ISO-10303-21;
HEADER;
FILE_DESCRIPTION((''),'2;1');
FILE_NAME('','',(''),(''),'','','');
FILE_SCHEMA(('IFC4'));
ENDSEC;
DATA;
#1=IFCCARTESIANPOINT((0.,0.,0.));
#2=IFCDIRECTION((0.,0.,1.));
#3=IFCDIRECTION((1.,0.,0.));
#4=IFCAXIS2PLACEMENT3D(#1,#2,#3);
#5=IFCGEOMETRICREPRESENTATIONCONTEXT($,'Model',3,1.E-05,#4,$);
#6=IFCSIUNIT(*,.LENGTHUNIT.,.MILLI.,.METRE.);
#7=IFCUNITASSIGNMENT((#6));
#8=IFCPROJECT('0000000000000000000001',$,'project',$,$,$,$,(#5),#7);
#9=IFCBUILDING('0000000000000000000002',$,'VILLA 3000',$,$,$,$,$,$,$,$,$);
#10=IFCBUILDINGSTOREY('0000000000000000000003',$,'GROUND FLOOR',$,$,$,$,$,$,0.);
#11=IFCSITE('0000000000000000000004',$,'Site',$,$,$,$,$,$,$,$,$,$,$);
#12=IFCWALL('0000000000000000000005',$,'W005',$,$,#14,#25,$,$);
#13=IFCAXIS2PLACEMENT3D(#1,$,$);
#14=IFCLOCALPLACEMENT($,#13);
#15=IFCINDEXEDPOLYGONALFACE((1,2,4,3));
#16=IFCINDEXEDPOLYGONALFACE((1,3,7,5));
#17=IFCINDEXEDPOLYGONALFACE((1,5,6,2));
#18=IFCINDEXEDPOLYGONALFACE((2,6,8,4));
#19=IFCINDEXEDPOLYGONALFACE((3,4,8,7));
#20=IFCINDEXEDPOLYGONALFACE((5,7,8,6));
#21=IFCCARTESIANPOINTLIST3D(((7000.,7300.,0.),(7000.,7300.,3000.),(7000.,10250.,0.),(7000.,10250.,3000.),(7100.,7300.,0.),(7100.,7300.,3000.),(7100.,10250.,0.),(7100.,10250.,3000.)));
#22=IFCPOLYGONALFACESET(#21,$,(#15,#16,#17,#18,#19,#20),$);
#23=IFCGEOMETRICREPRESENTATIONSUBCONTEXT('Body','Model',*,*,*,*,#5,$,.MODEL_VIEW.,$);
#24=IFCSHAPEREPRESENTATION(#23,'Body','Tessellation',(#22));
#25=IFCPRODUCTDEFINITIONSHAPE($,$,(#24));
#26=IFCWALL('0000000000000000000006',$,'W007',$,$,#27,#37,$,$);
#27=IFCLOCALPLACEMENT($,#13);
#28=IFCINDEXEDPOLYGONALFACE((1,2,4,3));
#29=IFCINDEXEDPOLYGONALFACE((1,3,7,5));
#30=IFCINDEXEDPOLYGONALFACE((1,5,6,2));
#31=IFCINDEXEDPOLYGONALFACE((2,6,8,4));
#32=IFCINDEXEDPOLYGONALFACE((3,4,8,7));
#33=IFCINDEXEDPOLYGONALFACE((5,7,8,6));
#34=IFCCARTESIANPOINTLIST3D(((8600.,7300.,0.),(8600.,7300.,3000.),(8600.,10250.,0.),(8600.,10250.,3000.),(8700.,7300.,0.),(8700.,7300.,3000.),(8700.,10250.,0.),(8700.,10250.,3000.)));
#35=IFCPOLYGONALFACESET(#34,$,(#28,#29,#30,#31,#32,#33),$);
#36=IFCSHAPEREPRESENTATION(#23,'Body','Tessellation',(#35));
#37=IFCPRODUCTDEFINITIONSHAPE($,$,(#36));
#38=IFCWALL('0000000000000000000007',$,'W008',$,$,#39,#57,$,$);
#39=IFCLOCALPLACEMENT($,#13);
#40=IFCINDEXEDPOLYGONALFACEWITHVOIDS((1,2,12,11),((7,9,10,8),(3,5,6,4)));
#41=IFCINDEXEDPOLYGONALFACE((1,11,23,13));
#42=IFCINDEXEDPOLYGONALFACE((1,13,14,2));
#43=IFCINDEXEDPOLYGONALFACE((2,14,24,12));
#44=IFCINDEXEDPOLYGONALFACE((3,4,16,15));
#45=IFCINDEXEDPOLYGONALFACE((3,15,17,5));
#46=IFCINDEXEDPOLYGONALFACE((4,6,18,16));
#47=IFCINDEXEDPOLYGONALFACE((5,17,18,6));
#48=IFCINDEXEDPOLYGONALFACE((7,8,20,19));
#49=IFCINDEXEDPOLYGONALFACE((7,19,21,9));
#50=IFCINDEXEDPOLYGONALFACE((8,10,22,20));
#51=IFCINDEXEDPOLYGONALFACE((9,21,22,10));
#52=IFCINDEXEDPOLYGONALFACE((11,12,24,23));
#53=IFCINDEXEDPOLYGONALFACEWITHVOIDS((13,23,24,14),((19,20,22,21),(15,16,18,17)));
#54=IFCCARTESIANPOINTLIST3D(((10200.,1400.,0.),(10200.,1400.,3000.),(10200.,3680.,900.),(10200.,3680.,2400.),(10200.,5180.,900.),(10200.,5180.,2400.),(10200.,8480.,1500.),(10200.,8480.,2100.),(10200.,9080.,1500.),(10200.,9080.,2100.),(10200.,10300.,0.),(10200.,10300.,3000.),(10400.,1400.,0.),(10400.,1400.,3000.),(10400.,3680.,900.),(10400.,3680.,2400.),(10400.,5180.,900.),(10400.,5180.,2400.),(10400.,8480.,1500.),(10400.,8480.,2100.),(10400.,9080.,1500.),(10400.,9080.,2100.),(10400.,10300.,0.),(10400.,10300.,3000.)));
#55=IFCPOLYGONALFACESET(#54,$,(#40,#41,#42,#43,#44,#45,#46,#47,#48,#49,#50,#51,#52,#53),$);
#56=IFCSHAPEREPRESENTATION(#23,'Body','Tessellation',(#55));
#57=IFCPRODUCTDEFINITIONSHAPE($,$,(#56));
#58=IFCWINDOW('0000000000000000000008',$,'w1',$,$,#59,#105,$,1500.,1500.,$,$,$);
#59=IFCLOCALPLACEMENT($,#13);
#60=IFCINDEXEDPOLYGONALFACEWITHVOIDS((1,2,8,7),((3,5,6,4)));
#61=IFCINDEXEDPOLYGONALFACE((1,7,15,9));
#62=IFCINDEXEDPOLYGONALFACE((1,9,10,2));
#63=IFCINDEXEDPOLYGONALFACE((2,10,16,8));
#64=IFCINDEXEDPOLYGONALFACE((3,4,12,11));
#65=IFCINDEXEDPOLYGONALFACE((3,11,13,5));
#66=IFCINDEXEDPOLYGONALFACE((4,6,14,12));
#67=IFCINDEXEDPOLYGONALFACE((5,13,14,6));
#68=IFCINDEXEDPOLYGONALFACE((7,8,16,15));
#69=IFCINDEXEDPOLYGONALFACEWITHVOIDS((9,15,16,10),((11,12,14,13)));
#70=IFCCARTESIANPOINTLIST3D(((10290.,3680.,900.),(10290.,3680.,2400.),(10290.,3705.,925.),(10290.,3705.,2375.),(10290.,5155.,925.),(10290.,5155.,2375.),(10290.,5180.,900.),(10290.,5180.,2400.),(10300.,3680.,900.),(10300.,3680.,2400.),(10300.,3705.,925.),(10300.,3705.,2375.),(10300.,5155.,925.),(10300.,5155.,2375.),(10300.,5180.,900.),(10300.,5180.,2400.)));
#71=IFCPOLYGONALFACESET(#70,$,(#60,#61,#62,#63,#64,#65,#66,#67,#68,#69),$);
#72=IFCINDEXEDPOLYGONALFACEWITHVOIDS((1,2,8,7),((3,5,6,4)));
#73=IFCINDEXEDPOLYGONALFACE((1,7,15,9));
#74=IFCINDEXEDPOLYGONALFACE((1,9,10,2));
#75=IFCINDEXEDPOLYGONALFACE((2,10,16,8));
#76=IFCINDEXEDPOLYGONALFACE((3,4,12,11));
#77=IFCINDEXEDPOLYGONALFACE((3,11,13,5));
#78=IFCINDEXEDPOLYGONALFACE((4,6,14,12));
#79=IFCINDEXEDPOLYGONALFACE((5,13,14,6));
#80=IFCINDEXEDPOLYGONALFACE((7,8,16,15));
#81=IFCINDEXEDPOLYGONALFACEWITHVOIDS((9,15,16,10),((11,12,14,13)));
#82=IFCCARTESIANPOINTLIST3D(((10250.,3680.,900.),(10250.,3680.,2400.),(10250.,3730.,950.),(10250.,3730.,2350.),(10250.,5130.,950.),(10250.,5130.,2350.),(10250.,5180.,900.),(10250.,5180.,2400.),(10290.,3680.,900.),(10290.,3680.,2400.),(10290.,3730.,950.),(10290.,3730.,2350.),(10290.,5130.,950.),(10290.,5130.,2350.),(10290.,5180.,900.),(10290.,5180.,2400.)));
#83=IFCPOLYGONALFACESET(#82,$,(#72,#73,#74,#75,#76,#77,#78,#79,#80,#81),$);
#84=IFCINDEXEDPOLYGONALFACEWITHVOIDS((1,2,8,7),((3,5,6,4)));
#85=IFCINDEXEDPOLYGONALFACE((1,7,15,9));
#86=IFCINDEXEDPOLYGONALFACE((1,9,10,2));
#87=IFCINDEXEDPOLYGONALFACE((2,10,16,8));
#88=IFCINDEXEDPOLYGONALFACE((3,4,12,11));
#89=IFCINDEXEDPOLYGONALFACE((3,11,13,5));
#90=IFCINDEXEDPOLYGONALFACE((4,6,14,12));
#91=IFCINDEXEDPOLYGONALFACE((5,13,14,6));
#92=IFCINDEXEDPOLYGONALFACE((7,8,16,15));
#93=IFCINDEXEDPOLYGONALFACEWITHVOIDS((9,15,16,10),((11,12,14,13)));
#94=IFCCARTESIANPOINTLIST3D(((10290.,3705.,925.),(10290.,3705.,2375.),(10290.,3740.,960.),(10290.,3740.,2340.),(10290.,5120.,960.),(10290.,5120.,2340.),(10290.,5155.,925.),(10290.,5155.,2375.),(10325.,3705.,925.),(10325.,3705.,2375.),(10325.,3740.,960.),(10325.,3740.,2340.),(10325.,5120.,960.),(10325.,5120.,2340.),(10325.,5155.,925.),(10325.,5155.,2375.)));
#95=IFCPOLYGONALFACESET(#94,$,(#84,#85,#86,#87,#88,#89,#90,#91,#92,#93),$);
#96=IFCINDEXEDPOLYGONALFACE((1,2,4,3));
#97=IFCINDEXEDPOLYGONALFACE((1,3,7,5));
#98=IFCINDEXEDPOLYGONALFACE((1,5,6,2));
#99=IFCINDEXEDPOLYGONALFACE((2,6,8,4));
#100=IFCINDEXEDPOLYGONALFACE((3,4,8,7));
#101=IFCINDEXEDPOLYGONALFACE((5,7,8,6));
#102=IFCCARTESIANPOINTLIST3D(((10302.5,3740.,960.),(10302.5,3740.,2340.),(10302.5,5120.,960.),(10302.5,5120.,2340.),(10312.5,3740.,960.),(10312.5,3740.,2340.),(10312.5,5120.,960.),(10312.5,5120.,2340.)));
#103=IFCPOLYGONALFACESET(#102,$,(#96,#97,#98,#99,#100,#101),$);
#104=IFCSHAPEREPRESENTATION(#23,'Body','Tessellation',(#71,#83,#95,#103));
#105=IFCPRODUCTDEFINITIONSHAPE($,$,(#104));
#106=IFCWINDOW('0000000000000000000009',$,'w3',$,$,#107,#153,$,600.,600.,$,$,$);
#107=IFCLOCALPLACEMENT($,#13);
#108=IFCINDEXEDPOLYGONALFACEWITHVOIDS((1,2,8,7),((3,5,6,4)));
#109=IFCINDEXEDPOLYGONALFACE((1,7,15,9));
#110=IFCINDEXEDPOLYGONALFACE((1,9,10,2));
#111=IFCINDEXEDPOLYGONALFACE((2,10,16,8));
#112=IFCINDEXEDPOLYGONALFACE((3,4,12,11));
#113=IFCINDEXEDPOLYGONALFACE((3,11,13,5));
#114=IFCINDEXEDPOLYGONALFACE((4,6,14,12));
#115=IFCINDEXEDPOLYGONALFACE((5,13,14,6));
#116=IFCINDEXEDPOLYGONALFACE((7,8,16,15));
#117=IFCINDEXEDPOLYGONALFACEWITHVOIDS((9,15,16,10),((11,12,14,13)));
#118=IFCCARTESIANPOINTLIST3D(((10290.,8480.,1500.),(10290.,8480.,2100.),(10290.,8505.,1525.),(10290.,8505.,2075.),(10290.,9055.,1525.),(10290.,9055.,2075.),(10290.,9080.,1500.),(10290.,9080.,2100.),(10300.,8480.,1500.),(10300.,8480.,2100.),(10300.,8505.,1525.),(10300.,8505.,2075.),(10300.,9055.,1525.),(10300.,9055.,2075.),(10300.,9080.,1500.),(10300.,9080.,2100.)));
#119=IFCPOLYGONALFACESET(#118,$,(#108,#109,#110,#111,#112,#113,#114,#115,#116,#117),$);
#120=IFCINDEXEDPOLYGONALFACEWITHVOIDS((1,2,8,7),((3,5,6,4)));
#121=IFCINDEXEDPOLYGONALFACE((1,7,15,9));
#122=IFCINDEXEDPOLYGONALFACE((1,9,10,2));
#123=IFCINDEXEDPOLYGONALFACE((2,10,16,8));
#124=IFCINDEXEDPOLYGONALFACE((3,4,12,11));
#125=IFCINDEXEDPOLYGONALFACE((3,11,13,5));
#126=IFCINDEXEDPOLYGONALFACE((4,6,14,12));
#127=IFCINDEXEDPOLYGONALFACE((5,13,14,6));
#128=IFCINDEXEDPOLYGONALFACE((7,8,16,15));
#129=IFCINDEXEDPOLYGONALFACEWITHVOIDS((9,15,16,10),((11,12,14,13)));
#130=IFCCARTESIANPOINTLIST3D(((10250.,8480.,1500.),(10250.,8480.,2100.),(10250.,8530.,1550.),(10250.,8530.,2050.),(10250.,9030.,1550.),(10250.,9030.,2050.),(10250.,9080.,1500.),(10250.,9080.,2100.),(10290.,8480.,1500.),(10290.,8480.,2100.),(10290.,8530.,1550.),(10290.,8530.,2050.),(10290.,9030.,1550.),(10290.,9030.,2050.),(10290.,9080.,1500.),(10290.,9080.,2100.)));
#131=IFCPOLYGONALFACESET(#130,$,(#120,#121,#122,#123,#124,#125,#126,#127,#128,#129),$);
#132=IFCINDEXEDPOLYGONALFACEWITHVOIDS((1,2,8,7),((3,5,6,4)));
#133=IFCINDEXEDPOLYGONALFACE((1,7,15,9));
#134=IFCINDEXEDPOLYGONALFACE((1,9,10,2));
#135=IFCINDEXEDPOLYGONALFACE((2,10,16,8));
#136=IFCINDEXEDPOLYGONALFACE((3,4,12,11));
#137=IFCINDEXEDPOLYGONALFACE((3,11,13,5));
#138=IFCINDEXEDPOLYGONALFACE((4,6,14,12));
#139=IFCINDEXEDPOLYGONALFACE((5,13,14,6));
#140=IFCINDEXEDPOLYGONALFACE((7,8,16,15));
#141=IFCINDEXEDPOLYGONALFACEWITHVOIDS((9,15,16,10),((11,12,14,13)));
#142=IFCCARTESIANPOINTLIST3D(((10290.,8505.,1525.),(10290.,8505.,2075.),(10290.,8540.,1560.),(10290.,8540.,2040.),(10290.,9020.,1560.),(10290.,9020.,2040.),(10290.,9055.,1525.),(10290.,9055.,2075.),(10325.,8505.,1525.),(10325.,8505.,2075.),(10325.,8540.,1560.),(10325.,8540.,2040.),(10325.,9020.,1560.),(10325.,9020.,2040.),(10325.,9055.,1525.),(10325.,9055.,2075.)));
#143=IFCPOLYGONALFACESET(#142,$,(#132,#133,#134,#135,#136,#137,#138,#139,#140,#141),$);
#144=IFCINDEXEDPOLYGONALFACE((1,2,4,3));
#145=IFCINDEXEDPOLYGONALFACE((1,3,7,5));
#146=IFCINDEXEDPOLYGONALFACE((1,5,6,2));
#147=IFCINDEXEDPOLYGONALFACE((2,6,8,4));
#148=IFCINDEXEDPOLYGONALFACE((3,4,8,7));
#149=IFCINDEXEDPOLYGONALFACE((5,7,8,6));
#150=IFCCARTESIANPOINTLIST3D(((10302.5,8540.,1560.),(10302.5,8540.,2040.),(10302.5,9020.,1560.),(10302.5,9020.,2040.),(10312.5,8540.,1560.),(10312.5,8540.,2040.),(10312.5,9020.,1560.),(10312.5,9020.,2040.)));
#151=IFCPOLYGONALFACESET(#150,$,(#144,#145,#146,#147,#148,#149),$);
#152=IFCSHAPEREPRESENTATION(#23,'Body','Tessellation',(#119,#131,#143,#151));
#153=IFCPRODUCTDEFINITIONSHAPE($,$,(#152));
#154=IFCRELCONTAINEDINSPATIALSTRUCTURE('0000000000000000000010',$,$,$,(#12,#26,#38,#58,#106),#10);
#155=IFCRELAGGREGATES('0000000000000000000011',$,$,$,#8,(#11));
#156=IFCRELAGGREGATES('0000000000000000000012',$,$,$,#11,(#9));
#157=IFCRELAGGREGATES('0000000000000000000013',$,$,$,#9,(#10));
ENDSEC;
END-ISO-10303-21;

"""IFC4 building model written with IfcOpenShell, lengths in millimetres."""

from ifc_helpers import new_model, si_unit, frame, origin_with_axes, place, context, subcontext, project, spatial, line, indexed_curve, outline, extrude, element, fill, save


model = new_model("IFC4")

# Units and contexts
model_context = context("Model", 3, precision=1e-05, world=origin_with_axes())
body_context = subcontext(model_context, "Body", "Model", "MODEL_VIEW")
ifc_project = project(units=[si_unit("LENGTHUNIT", "METRE", prefix="MILLI")], contexts=[model_context])

# Site, building, storey
site = spatial("IfcSite", under=ifc_project, Name="Site")
building = spatial("IfcBuilding", under=site, Name="VILLA 3000")
storey = spatial("IfcBuildingStorey", under=building, Name="GROUND FLOOR", Elevation=0.0)

# Walls
for number, where, z_axis, x_axis, name in (
    (1, (7050.0, 10250.0, 0.0), (0.0, 0.0, 1.0), (0.0, -1.0, 0.0), "W005"),
    (2, (8650.0, 10250.0, 0.0), (0.0, 0.0, 1.0), (0.0, -1.0, 0.0), "W007"),
):
    element("IfcWall", number, at=place(None, frame(where, z_axis=z_axis, x_axis=x_axis)), inside=storey, Name=name, context=body_context, shape_type="SweptSolid", body=[
        extrude(outline(indexed_curve([(0.0, 0.0), (0.0, 100.0), (2950.0, 100.0), (2950.0, 0.0), (0.0, 0.0)], self_intersect=False)), frame((0.0, -50.0, 0.0), z_axis=(0.0, 0.0, 1.0), x_axis=(1.0, 0.0, 0.0)), (0.0, 0.0, 1.0), 3000.0),
    ])

# Wall, openings, windows
wall_1_placement = place(None, frame((10300.0, 10300.0, 0.0), z_axis=(0.0, 0.0, 1.0), x_axis=(0.0, -1.0, 0.0)))
wall_1 = element("IfcWall", 3, at=wall_1_placement, inside=storey, Name="W008", context=body_context, shape_type="SweptSolid", body=[
    extrude(outline(indexed_curve([(0.0, 0.0), (0.0, 200.0), (8900.0, 200.0), (8900.0, 0.0), (0.0, 0.0)], self_intersect=False)), frame((0.0, -100.0, 0.0), z_axis=(0.0, 0.0, 1.0), x_axis=(1.0, 0.0, 0.0)), (0.0, 0.0, 1.0), 3000.0),
])
opening_1_placement = place(wall_1_placement, frame((5120.0, 0.0, 900.0), z_axis=(0.0, 0.0, 1.0), x_axis=(1.0, 0.0, 0.0)))
opening_1 = element("IfcOpeningElement", 4, at=opening_1_placement, cuts=wall_1, context=body_context, shape_type="SweptSolid", body=[
    extrude(outline(indexed_curve([(0.0, 0.0), (0.0, 300.0), (1500.0, 300.0), (1500.0, 0.0), (0.0, 0.0)], self_intersect=False)), frame((0.0, -150.0, 0.0), z_axis=(0.0, 0.0, 1.0), x_axis=(1.0, 0.0, 0.0)), (0.0, 0.0, 1.0), 1500.0),
])
opening_2_placement = place(wall_1_placement, frame((1220.0, 0.0, 1500.0), z_axis=(0.0, 0.0, 1.0), x_axis=(1.0, 0.0, 0.0)))
opening_2 = element("IfcOpeningElement", 5, at=opening_2_placement, cuts=wall_1, context=body_context, shape_type="SweptSolid", body=[
    extrude(outline(indexed_curve([(0.0, 0.0), (0.0, 300.0), (600.0, 300.0), (600.0, 0.0), (0.0, 0.0)], self_intersect=False)), frame((0.0, -150.0, 0.0), z_axis=(0.0, 0.0, 1.0), x_axis=(1.0, 0.0, 0.0)), (0.0, 0.0, 1.0), 600.0),
])
window_1_placement = place(None, frame((10200.0, 5180.0, 900.0), z_axis=(0.0, 0.0, 1.0), x_axis=(0.0, -1.0, 0.0)))
window_1 = element("IfcWindow", 6, at=window_1_placement, inside=storey, Name="w1", OverallHeight=1500.0, OverallWidth=1500.0, context=body_context, shape_type="SweptSolid", body=[
    extrude(outline(indexed_curve([(0.0, 0.0), (1500.0, 0.0), (1500.0, 1500.0), (0.0, 1500.0)], segments=[line(1, 2, 3, 4, 1)]), holes=[indexed_curve([(25.0, 25.0), (1475.0, 25.0), (1475.0, 1475.0), (25.0, 1475.0)], segments=[line(1, 2, 3, 4, 1)])]), frame((0.0, 90.0, 0.0), z_axis=(0.0, -1.0, 0.0), x_axis=(1.0, 0.0, 0.0)), (0.0, 0.0, -1.0), 10.0),
    extrude(outline(indexed_curve([(0.0, 0.0), (1500.0, 0.0), (1500.0, 1500.0), (0.0, 1500.0)], segments=[line(1, 2, 3, 4, 1)]), holes=[indexed_curve([(50.0, 50.0), (1450.0, 50.0), (1450.0, 1450.0), (50.0, 1450.0)], segments=[line(1, 2, 3, 4, 1)])]), frame((0.0, 50.0, 0.0), z_axis=(0.0, -1.0, 0.0), x_axis=(1.0, 0.0, 0.0)), (0.0, 0.0, -1.0), 40.0),
    extrude(outline(indexed_curve([(0.0, 0.0), (1450.0, 0.0), (1450.0, 1450.0), (0.0, 1450.0)], segments=[line(1, 2, 3, 4, 1)]), holes=[indexed_curve([(35.0, 35.0), (1415.0, 35.0), (1415.0, 1415.0), (35.0, 1415.0)], segments=[line(1, 2, 3, 4, 1)])]), frame((25.0, 90.0, 25.0), z_axis=(0.0, -1.0, 0.0), x_axis=(1.0, 0.0, 0.0)), (0.0, 0.0, -1.0), 35.0),
    extrude(outline(indexed_curve([(35.0, 35.0), (1415.0, 35.0), (1415.0, 1415.0), (35.0, 1415.0)], segments=[line(1, 2, 3, 4, 1)])), frame((25.0, 102.5, 25.0), z_axis=(0.0, -1.0, 0.0), x_axis=(1.0, 0.0, 0.0)), (0.0, 0.0, -1.0), 10.0),
])
fill(opening_1, window_1)
window_2_placement = place(None, frame((10200.0, 9080.0, 1500.0), z_axis=(0.0, 0.0, 1.0), x_axis=(0.0, -1.0, 0.0)))
window_2 = element("IfcWindow", 7, at=window_2_placement, inside=storey, Name="w3", OverallHeight=600.0, OverallWidth=600.0, context=body_context, shape_type="SweptSolid", body=[
    extrude(outline(indexed_curve([(0.0, 0.0), (600.0, 0.0), (600.0, 600.0), (0.0, 600.0)], segments=[line(1, 2, 3, 4, 1)]), holes=[indexed_curve([(25.0, 25.0), (575.0, 25.0), (575.0, 575.0), (25.0, 575.0)], segments=[line(1, 2, 3, 4, 1)])]), frame((0.0, 90.0, 0.0), z_axis=(0.0, -1.0, 0.0), x_axis=(1.0, 0.0, 0.0)), (0.0, 0.0, -1.0), 10.0),
    extrude(outline(indexed_curve([(0.0, 0.0), (600.0, 0.0), (600.0, 600.0), (0.0, 600.0)], segments=[line(1, 2, 3, 4, 1)]), holes=[indexed_curve([(50.0, 50.0), (550.0, 50.0), (550.0, 550.0), (50.0, 550.0)], segments=[line(1, 2, 3, 4, 1)])]), frame((0.0, 50.0, 0.0), z_axis=(0.0, -1.0, 0.0), x_axis=(1.0, 0.0, 0.0)), (0.0, 0.0, -1.0), 40.0),
    extrude(outline(indexed_curve([(0.0, 0.0), (550.0, 0.0), (550.0, 550.0), (0.0, 550.0)], segments=[line(1, 2, 3, 4, 1)]), holes=[indexed_curve([(35.0, 35.0), (515.0, 35.0), (515.0, 515.0), (35.0, 515.0)], segments=[line(1, 2, 3, 4, 1)])]), frame((25.0, 90.0, 25.0), z_axis=(0.0, -1.0, 0.0), x_axis=(1.0, 0.0, 0.0)), (0.0, 0.0, -1.0), 35.0),
    extrude(outline(indexed_curve([(35.0, 35.0), (515.0, 35.0), (515.0, 515.0), (35.0, 515.0)], segments=[line(1, 2, 3, 4, 1)])), frame((25.0, 102.5, 25.0), z_axis=(0.0, -1.0, 0.0), x_axis=(1.0, 0.0, 0.0)), (0.0, 0.0, -1.0), 10.0),
])
fill(opening_2, window_2)

save(model, "model.ifc")
